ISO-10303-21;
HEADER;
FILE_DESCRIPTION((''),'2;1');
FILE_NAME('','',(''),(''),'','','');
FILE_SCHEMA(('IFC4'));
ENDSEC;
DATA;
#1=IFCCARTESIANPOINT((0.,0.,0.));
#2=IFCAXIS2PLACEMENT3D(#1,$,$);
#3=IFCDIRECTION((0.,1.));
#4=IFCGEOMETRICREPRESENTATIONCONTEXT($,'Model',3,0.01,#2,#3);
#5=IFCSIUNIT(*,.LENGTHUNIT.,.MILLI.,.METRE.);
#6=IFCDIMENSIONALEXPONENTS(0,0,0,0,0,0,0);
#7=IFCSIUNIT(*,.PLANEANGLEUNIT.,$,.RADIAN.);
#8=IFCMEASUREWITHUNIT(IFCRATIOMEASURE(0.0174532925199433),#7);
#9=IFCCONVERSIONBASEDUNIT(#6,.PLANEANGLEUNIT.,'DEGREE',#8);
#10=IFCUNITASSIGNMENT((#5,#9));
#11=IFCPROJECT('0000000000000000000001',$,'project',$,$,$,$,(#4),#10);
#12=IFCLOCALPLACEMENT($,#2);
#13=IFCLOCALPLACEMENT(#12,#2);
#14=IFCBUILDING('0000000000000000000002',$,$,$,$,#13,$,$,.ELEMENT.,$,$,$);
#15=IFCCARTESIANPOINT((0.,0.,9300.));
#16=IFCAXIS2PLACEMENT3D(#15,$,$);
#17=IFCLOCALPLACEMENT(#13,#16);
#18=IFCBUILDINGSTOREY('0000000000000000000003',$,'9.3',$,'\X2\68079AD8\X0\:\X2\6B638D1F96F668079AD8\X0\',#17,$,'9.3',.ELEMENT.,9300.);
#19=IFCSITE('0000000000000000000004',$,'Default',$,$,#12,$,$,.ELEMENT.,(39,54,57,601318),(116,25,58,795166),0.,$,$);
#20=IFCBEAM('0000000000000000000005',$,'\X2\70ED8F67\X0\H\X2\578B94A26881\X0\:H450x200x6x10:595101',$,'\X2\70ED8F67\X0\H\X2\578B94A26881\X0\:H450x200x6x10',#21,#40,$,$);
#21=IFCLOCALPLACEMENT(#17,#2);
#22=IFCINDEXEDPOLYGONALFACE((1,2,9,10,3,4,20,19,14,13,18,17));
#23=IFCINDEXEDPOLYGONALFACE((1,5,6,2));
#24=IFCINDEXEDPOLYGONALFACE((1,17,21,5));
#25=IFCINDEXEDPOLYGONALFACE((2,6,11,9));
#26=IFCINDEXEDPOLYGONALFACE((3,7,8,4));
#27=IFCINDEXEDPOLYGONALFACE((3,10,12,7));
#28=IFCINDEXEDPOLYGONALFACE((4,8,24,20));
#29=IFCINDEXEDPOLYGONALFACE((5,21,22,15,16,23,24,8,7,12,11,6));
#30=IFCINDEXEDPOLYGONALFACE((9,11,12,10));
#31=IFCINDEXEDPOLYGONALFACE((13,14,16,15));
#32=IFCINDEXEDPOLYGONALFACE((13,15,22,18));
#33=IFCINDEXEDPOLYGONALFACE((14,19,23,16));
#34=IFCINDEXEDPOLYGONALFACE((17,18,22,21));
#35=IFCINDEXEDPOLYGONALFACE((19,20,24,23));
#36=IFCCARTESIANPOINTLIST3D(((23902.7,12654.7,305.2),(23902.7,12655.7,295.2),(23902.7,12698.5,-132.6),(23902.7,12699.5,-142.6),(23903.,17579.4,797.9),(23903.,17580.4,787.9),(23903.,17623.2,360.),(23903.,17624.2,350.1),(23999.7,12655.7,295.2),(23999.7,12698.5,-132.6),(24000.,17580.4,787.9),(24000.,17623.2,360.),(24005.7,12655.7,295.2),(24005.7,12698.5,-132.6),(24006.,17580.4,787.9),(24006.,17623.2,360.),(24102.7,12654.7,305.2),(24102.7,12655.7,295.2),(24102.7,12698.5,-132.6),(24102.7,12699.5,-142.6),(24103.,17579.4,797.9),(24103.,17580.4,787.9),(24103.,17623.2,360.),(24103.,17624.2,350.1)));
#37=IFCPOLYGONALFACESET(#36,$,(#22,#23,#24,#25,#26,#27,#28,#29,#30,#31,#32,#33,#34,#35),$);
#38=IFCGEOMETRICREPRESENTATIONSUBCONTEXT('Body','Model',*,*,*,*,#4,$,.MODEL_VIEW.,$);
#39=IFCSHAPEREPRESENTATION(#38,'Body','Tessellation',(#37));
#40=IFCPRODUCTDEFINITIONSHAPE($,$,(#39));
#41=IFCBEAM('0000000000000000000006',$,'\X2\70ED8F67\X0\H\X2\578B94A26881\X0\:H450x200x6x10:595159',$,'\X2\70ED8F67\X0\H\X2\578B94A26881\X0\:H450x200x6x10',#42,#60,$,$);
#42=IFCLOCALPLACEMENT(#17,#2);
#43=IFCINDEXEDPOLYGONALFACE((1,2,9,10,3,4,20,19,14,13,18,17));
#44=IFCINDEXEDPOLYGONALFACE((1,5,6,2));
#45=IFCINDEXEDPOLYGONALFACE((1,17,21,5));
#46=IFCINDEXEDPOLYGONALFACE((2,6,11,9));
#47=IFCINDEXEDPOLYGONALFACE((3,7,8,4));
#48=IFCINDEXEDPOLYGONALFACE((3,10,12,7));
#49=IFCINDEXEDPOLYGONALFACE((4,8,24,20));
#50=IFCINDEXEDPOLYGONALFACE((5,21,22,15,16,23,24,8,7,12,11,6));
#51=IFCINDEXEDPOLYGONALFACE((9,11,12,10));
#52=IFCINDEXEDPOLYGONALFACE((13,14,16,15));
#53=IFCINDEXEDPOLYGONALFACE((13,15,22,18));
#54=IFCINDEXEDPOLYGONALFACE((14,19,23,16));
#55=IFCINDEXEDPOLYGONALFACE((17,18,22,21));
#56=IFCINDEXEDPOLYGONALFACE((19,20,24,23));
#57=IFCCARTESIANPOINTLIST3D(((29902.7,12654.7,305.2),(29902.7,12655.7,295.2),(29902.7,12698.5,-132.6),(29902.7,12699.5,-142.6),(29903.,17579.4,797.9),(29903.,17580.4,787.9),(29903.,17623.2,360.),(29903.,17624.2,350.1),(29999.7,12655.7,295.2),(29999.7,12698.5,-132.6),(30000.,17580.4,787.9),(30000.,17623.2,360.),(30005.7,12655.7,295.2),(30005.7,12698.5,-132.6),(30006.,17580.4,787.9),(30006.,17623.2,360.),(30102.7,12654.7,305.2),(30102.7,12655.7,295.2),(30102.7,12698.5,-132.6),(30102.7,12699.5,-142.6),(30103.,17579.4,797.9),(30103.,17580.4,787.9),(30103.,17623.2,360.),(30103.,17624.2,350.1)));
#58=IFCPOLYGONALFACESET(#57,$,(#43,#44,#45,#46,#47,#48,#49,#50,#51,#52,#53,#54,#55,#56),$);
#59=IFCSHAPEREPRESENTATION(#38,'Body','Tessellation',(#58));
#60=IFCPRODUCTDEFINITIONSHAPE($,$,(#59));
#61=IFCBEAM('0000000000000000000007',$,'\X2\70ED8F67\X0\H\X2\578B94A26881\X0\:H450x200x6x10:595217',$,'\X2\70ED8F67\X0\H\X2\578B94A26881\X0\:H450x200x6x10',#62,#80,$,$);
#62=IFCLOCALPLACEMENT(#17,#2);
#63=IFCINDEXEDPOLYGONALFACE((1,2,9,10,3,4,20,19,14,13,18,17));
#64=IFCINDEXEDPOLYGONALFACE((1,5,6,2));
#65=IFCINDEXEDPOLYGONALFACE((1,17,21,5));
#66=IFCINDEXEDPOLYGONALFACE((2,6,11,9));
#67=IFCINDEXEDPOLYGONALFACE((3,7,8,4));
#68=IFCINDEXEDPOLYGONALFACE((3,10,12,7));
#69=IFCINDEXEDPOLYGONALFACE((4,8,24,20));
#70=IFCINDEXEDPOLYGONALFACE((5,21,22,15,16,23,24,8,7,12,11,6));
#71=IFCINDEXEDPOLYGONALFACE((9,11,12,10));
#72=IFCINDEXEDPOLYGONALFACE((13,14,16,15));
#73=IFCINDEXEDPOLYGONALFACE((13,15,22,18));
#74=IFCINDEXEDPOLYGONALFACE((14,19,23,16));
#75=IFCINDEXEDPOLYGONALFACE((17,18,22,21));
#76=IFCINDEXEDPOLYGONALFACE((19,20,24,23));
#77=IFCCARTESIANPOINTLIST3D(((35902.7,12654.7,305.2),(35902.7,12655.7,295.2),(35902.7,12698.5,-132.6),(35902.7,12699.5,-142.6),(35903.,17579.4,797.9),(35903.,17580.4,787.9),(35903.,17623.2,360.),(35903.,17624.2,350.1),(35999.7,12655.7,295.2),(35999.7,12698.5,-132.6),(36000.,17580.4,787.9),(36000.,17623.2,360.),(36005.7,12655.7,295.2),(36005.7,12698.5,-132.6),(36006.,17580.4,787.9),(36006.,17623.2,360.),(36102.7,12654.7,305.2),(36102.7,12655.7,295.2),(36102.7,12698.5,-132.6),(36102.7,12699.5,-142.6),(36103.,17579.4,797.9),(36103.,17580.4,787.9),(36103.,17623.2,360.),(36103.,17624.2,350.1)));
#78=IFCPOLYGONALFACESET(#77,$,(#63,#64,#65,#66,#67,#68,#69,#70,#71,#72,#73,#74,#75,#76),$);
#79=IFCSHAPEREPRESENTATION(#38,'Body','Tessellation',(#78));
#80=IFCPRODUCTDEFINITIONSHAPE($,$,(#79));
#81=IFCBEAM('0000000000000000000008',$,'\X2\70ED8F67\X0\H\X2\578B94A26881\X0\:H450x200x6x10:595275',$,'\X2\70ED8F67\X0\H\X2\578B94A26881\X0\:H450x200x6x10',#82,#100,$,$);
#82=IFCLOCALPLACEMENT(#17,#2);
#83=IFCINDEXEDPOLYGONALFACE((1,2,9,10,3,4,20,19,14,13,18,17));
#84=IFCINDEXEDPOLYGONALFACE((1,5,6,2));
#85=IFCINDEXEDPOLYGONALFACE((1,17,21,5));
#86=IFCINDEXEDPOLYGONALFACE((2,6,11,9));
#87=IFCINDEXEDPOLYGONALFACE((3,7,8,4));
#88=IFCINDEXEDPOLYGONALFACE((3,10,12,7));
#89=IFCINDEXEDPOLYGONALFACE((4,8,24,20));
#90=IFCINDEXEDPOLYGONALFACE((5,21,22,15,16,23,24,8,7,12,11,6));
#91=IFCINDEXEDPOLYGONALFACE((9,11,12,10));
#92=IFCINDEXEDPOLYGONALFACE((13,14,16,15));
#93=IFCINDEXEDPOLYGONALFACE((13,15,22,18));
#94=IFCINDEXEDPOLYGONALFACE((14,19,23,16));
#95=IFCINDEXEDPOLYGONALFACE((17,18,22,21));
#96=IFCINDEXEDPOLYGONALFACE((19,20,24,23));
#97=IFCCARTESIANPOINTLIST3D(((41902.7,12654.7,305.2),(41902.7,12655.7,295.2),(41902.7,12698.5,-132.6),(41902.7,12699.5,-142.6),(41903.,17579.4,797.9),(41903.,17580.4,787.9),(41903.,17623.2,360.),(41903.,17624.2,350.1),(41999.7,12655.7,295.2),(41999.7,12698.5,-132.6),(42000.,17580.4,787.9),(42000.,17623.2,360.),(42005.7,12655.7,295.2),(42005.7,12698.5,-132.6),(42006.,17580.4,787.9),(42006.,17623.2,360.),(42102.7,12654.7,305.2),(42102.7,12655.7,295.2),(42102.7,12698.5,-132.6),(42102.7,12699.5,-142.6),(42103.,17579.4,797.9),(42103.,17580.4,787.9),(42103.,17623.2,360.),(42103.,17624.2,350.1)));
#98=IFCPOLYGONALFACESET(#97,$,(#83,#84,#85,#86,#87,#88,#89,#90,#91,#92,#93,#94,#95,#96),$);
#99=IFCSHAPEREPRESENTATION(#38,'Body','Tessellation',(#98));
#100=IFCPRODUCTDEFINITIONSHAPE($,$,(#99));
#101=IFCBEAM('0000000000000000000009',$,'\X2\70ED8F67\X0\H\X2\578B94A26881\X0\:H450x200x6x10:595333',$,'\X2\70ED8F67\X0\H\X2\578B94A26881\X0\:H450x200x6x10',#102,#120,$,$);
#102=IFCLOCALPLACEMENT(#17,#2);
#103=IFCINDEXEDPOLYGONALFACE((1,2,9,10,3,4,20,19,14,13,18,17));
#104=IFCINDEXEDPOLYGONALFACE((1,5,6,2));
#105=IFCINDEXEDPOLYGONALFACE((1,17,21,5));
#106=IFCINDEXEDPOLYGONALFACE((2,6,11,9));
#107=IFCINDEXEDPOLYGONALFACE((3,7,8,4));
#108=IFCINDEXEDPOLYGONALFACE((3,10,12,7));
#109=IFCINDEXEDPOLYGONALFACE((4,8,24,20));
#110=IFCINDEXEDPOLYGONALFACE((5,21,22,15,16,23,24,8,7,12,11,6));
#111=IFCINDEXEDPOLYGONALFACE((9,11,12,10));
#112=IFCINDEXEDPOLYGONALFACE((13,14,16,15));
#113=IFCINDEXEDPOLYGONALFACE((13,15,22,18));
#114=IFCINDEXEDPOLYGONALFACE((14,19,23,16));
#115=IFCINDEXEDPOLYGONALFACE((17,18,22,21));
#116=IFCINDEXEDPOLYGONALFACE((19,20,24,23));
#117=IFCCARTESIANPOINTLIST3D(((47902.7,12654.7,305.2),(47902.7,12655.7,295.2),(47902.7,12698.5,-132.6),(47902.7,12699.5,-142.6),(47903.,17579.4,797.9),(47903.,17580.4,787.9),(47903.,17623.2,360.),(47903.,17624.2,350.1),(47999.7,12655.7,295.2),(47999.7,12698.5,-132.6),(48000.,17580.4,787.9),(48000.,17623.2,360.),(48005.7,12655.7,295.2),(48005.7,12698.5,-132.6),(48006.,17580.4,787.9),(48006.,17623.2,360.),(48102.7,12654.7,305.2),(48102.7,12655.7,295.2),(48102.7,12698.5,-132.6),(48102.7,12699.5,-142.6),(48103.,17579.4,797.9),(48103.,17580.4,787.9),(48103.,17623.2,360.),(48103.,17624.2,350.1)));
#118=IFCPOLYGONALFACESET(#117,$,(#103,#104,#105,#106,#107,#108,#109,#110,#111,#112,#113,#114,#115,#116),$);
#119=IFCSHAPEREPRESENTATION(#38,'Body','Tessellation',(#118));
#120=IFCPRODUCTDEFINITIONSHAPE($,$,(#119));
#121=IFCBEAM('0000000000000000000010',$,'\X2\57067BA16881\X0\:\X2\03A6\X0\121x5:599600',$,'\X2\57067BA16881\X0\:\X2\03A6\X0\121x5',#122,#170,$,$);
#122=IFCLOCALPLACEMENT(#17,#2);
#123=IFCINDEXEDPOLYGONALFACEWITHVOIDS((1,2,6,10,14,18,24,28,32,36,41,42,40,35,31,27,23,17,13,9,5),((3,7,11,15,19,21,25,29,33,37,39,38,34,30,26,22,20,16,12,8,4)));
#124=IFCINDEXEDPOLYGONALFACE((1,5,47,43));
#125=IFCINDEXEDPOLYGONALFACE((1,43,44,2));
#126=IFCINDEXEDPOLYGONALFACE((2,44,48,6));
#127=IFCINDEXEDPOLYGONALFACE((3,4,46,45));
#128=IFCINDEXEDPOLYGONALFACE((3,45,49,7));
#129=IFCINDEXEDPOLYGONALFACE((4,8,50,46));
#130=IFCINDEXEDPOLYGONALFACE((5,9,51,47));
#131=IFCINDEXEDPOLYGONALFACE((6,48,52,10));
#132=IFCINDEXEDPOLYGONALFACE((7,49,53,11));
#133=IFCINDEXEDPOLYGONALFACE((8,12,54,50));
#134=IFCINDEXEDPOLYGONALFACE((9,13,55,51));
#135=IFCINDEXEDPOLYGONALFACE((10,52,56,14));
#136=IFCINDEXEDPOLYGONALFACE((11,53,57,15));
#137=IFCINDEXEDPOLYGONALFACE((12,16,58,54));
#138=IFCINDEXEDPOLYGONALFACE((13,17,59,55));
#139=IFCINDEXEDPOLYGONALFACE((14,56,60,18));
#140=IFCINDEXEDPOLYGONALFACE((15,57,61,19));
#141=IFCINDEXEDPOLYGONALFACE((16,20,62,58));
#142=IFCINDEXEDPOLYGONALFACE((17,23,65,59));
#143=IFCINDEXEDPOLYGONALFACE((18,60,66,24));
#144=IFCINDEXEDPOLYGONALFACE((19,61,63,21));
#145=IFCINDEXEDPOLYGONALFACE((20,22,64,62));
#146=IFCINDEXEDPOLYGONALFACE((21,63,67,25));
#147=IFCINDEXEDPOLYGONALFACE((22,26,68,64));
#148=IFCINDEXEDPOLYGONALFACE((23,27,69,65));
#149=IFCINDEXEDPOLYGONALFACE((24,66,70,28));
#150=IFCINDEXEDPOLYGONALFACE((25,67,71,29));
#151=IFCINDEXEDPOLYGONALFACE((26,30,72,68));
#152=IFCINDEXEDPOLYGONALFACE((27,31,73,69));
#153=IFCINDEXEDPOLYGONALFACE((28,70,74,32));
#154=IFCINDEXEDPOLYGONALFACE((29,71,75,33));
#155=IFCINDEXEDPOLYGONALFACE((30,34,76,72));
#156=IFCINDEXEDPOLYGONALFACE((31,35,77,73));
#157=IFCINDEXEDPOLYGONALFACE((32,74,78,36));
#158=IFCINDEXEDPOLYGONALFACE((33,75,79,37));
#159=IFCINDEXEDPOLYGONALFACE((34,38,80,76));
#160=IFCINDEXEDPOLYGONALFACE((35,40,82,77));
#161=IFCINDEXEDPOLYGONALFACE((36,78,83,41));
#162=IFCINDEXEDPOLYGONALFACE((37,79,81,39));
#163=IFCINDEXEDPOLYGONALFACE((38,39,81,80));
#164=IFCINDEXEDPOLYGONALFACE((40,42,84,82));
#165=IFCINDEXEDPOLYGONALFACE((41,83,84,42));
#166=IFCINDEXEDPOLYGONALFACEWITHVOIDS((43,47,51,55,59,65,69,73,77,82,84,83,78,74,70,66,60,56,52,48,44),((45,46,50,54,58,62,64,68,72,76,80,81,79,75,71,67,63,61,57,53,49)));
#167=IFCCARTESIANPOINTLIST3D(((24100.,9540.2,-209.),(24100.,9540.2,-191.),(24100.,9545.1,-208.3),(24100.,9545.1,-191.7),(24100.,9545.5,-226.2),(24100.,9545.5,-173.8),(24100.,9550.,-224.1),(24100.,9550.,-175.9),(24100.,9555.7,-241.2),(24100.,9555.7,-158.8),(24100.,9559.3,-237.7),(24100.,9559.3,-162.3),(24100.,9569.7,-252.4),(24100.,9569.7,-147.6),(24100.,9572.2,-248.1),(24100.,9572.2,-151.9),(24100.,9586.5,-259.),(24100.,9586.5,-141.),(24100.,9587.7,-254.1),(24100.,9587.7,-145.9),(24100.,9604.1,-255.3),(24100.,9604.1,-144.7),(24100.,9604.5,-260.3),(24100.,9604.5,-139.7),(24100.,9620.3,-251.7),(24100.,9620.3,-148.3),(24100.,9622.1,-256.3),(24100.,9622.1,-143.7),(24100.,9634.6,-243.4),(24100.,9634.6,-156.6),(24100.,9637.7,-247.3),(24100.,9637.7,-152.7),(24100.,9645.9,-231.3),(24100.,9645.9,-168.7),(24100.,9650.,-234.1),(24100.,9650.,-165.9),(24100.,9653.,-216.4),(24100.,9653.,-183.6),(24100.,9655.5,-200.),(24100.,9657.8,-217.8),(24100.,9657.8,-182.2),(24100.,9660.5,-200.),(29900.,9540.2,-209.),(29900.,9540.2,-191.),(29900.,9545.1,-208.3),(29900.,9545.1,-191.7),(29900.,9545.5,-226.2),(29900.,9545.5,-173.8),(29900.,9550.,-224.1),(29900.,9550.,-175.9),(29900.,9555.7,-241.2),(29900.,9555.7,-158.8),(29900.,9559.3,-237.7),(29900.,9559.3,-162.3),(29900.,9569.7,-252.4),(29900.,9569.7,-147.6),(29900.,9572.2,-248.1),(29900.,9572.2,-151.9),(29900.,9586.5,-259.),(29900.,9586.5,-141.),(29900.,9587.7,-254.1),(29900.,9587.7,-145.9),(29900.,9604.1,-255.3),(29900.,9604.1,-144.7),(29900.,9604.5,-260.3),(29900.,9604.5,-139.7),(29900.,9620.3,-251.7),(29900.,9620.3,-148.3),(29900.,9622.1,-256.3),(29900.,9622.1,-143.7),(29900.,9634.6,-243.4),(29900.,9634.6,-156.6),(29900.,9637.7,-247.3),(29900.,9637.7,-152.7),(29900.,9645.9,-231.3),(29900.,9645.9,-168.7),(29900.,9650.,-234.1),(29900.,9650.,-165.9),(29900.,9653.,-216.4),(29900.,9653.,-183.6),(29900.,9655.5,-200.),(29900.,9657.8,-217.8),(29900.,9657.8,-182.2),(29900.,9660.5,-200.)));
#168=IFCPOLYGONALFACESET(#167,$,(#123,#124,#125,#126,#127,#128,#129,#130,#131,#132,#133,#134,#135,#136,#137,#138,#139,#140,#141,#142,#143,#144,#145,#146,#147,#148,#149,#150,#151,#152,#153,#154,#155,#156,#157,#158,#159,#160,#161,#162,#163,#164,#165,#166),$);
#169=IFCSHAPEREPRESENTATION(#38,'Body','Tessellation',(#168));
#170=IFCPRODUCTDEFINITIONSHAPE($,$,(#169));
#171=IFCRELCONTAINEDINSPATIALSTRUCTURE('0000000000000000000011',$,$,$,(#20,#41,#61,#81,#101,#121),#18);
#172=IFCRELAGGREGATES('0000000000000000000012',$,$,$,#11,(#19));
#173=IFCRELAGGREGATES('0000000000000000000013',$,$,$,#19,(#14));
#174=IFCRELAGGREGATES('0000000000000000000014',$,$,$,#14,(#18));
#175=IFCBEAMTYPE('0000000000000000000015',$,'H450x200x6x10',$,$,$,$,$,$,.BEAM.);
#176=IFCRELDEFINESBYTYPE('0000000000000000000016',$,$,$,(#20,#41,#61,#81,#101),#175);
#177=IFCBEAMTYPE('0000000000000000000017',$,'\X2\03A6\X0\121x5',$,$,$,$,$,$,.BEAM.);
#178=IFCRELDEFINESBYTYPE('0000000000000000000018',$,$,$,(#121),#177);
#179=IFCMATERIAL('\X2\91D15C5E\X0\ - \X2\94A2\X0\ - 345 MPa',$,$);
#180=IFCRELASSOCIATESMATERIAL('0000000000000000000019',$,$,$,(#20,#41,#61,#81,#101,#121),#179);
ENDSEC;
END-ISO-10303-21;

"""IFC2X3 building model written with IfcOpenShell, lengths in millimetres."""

from ifc_helpers import new_model, entity, si_unit, converted_unit, direction, frame, frame_2d, origin, origin_2d_with_axis, place, context, subcontext, project, spatial, hollow_circle, i_section, extrude, material, type_object, element, save


model = new_model("IFC2X3")

# Units and contexts
model_context = context("Model", 3, precision=0.01, world=origin(), true_north=direction((0.0, 1.0)))
body_context = subcontext(model_context, "Body", "Model", "MODEL_VIEW")
ifc_project = project(units=[si_unit("LENGTHUNIT", "METRE", prefix="MILLI"), converted_unit("PLANEANGLEUNIT", "DEGREE", entity("IfcRatioMeasure", 0.0174532925199433), si_unit("PLANEANGLEUNIT", "RADIAN"), dimensions=[0, 0, 0, 0, 0, 0, 0])], contexts=[model_context])

# Site, building, storey
site_placement = place(None, origin())
site = spatial("IfcSite", under=ifc_project, at=site_placement, Name="Default", CompositionType="ELEMENT", RefLatitude=(39, 54, 57, 601318), RefLongitude=(116, 25, 58, 795166), RefElevation=0.0)
building_placement = place(site_placement, origin())
building = spatial("IfcBuilding", under=site, at=building_placement, CompositionType="ELEMENT")
storey_placement = place(building_placement, frame((0.0, 0.0, 9300.0)))
storey = spatial("IfcBuildingStorey", under=building, at=storey_placement, Name="9.3", ObjectType="标高:正负零标高", LongName="9.3", CompositionType="ELEMENT", Elevation=9300.0)

# Beams
ifc_material = material(Name="金属 - 钢 - 345 MPa")
beam_type_1 = type_object("IfcBeamType", Name="H450x200x6x10", PredefinedType="BEAM")
beam_1_placement = place(storey_placement, frame((24002.7, 12639.5, 303.6), z_axis=(-0.000005, -0.099548, 0.995033), x_axis=(0.000053, 0.995033, 0.099548)))
element("IfcBeam", 1, at=beam_1_placement, inside=storey, type_object=beam_type_1, material=ifc_material, Name="热轧H型钢梁:H450x200x6x10:595101", ObjectType="热轧H型钢梁:H450x200x6x10", context=body_context, shape_type="SweptSolid", body=[
    extrude(i_section(OverallWidth=200.0, OverallDepth=450.0, WebThickness=6.0, FlangeThickness=10.0, at=frame_2d((0.0, 0.0), x_axis=(0.0, 1.0))), frame((15.3, 0.0, -225.0), z_axis=(1.0, 0.0, 0.0), x_axis=(0.0, 0.0, -1.0)), (0.0, 0.0, 1.0), 4949.3),
])
beam_2_placement = place(storey_placement, frame((30002.7, 12639.5, 303.6), z_axis=(-0.000005, -0.099548, 0.995033), x_axis=(0.000053, 0.995033, 0.099548)))
element("IfcBeam", 2, at=beam_2_placement, inside=storey, type_object=beam_type_1, material=ifc_material, Name="热轧H型钢梁:H450x200x6x10:595159", ObjectType="热轧H型钢梁:H450x200x6x10", context=body_context, shape_type="SweptSolid", body=[
    extrude(i_section(OverallWidth=200.0, OverallDepth=450.0, WebThickness=6.0, FlangeThickness=10.0, at=frame_2d((0.0, 0.0), x_axis=(0.0, 1.0))), frame((15.3, 0.0, -225.0), z_axis=(1.0, 0.0, 0.0), x_axis=(0.0, 0.0, -1.0)), (0.0, 0.0, 1.0), 4949.3),
])
beam_3_placement = place(storey_placement, frame((36002.7, 12639.5, 303.6), z_axis=(-0.000005, -0.099548, 0.995033), x_axis=(0.000053, 0.995033, 0.099548)))
element("IfcBeam", 3, at=beam_3_placement, inside=storey, type_object=beam_type_1, material=ifc_material, Name="热轧H型钢梁:H450x200x6x10:595217", ObjectType="热轧H型钢梁:H450x200x6x10", context=body_context, shape_type="SweptSolid", body=[
    extrude(i_section(OverallWidth=200.0, OverallDepth=450.0, WebThickness=6.0, FlangeThickness=10.0, at=frame_2d((0.0, 0.0), x_axis=(0.0, 1.0))), frame((15.3, 0.0, -225.0), z_axis=(1.0, 0.0, 0.0), x_axis=(0.0, 0.0, -1.0)), (0.0, 0.0, 1.0), 4949.3),
])
beam_4_placement = place(storey_placement, frame((42002.7, 12639.5, 303.6), z_axis=(-0.000005, -0.099548, 0.995033), x_axis=(0.000053, 0.995033, 0.099548)))
element("IfcBeam", 4, at=beam_4_placement, inside=storey, type_object=beam_type_1, material=ifc_material, Name="热轧H型钢梁:H450x200x6x10:595275", ObjectType="热轧H型钢梁:H450x200x6x10", context=body_context, shape_type="SweptSolid", body=[
    extrude(i_section(OverallWidth=200.0, OverallDepth=450.0, WebThickness=6.0, FlangeThickness=10.0, at=frame_2d((0.0, 0.0), x_axis=(0.0, 1.0))), frame((15.3, 0.0, -225.0), z_axis=(1.0, 0.0, 0.0), x_axis=(0.0, 0.0, -1.0)), (0.0, 0.0, 1.0), 4949.3),
])
beam_5_placement = place(storey_placement, frame((48002.7, 12639.5, 303.6), z_axis=(-0.000005, -0.099548, 0.995033), x_axis=(0.000053, 0.995033, 0.099548)))
element("IfcBeam", 5, at=beam_5_placement, inside=storey, type_object=beam_type_1, material=ifc_material, Name="热轧H型钢梁:H450x200x6x10:595333", ObjectType="热轧H型钢梁:H450x200x6x10", context=body_context, shape_type="SweptSolid", body=[
    extrude(i_section(OverallWidth=200.0, OverallDepth=450.0, WebThickness=6.0, FlangeThickness=10.0, at=frame_2d((0.0, 0.0), x_axis=(0.0, 1.0))), frame((15.3, 0.0, -225.0), z_axis=(1.0, 0.0, 0.0), x_axis=(0.0, 0.0, -1.0)), (0.0, 0.0, 1.0), 4949.3),
])
beam_type_2 = type_object("IfcBeamType", Name="Φ121x5", PredefinedType="BEAM")
for number, where, name in (
    (6, (24000.0, 9600.0, 0.0), "圆管梁:Φ121x5:599600"),
):
    element("IfcBeam", number, at=place(storey_placement, frame(where)), inside=storey, type_object=beam_type_2, material=ifc_material, Name=name, ObjectType="圆管梁:Φ121x5", context=body_context, shape_type="SweptSolid", body=[
        extrude(hollow_circle(Radius=60.5, WallThickness=5.0, at=origin_2d_with_axis()), frame((100.0, 0.0, -200.0), z_axis=(1.0, 0.0, 0.0), x_axis=(0.0, 1.0, 0.0)), (0.0, 0.0, 1.0), 5800.0),
    ])

save(model, "model.ifc")
